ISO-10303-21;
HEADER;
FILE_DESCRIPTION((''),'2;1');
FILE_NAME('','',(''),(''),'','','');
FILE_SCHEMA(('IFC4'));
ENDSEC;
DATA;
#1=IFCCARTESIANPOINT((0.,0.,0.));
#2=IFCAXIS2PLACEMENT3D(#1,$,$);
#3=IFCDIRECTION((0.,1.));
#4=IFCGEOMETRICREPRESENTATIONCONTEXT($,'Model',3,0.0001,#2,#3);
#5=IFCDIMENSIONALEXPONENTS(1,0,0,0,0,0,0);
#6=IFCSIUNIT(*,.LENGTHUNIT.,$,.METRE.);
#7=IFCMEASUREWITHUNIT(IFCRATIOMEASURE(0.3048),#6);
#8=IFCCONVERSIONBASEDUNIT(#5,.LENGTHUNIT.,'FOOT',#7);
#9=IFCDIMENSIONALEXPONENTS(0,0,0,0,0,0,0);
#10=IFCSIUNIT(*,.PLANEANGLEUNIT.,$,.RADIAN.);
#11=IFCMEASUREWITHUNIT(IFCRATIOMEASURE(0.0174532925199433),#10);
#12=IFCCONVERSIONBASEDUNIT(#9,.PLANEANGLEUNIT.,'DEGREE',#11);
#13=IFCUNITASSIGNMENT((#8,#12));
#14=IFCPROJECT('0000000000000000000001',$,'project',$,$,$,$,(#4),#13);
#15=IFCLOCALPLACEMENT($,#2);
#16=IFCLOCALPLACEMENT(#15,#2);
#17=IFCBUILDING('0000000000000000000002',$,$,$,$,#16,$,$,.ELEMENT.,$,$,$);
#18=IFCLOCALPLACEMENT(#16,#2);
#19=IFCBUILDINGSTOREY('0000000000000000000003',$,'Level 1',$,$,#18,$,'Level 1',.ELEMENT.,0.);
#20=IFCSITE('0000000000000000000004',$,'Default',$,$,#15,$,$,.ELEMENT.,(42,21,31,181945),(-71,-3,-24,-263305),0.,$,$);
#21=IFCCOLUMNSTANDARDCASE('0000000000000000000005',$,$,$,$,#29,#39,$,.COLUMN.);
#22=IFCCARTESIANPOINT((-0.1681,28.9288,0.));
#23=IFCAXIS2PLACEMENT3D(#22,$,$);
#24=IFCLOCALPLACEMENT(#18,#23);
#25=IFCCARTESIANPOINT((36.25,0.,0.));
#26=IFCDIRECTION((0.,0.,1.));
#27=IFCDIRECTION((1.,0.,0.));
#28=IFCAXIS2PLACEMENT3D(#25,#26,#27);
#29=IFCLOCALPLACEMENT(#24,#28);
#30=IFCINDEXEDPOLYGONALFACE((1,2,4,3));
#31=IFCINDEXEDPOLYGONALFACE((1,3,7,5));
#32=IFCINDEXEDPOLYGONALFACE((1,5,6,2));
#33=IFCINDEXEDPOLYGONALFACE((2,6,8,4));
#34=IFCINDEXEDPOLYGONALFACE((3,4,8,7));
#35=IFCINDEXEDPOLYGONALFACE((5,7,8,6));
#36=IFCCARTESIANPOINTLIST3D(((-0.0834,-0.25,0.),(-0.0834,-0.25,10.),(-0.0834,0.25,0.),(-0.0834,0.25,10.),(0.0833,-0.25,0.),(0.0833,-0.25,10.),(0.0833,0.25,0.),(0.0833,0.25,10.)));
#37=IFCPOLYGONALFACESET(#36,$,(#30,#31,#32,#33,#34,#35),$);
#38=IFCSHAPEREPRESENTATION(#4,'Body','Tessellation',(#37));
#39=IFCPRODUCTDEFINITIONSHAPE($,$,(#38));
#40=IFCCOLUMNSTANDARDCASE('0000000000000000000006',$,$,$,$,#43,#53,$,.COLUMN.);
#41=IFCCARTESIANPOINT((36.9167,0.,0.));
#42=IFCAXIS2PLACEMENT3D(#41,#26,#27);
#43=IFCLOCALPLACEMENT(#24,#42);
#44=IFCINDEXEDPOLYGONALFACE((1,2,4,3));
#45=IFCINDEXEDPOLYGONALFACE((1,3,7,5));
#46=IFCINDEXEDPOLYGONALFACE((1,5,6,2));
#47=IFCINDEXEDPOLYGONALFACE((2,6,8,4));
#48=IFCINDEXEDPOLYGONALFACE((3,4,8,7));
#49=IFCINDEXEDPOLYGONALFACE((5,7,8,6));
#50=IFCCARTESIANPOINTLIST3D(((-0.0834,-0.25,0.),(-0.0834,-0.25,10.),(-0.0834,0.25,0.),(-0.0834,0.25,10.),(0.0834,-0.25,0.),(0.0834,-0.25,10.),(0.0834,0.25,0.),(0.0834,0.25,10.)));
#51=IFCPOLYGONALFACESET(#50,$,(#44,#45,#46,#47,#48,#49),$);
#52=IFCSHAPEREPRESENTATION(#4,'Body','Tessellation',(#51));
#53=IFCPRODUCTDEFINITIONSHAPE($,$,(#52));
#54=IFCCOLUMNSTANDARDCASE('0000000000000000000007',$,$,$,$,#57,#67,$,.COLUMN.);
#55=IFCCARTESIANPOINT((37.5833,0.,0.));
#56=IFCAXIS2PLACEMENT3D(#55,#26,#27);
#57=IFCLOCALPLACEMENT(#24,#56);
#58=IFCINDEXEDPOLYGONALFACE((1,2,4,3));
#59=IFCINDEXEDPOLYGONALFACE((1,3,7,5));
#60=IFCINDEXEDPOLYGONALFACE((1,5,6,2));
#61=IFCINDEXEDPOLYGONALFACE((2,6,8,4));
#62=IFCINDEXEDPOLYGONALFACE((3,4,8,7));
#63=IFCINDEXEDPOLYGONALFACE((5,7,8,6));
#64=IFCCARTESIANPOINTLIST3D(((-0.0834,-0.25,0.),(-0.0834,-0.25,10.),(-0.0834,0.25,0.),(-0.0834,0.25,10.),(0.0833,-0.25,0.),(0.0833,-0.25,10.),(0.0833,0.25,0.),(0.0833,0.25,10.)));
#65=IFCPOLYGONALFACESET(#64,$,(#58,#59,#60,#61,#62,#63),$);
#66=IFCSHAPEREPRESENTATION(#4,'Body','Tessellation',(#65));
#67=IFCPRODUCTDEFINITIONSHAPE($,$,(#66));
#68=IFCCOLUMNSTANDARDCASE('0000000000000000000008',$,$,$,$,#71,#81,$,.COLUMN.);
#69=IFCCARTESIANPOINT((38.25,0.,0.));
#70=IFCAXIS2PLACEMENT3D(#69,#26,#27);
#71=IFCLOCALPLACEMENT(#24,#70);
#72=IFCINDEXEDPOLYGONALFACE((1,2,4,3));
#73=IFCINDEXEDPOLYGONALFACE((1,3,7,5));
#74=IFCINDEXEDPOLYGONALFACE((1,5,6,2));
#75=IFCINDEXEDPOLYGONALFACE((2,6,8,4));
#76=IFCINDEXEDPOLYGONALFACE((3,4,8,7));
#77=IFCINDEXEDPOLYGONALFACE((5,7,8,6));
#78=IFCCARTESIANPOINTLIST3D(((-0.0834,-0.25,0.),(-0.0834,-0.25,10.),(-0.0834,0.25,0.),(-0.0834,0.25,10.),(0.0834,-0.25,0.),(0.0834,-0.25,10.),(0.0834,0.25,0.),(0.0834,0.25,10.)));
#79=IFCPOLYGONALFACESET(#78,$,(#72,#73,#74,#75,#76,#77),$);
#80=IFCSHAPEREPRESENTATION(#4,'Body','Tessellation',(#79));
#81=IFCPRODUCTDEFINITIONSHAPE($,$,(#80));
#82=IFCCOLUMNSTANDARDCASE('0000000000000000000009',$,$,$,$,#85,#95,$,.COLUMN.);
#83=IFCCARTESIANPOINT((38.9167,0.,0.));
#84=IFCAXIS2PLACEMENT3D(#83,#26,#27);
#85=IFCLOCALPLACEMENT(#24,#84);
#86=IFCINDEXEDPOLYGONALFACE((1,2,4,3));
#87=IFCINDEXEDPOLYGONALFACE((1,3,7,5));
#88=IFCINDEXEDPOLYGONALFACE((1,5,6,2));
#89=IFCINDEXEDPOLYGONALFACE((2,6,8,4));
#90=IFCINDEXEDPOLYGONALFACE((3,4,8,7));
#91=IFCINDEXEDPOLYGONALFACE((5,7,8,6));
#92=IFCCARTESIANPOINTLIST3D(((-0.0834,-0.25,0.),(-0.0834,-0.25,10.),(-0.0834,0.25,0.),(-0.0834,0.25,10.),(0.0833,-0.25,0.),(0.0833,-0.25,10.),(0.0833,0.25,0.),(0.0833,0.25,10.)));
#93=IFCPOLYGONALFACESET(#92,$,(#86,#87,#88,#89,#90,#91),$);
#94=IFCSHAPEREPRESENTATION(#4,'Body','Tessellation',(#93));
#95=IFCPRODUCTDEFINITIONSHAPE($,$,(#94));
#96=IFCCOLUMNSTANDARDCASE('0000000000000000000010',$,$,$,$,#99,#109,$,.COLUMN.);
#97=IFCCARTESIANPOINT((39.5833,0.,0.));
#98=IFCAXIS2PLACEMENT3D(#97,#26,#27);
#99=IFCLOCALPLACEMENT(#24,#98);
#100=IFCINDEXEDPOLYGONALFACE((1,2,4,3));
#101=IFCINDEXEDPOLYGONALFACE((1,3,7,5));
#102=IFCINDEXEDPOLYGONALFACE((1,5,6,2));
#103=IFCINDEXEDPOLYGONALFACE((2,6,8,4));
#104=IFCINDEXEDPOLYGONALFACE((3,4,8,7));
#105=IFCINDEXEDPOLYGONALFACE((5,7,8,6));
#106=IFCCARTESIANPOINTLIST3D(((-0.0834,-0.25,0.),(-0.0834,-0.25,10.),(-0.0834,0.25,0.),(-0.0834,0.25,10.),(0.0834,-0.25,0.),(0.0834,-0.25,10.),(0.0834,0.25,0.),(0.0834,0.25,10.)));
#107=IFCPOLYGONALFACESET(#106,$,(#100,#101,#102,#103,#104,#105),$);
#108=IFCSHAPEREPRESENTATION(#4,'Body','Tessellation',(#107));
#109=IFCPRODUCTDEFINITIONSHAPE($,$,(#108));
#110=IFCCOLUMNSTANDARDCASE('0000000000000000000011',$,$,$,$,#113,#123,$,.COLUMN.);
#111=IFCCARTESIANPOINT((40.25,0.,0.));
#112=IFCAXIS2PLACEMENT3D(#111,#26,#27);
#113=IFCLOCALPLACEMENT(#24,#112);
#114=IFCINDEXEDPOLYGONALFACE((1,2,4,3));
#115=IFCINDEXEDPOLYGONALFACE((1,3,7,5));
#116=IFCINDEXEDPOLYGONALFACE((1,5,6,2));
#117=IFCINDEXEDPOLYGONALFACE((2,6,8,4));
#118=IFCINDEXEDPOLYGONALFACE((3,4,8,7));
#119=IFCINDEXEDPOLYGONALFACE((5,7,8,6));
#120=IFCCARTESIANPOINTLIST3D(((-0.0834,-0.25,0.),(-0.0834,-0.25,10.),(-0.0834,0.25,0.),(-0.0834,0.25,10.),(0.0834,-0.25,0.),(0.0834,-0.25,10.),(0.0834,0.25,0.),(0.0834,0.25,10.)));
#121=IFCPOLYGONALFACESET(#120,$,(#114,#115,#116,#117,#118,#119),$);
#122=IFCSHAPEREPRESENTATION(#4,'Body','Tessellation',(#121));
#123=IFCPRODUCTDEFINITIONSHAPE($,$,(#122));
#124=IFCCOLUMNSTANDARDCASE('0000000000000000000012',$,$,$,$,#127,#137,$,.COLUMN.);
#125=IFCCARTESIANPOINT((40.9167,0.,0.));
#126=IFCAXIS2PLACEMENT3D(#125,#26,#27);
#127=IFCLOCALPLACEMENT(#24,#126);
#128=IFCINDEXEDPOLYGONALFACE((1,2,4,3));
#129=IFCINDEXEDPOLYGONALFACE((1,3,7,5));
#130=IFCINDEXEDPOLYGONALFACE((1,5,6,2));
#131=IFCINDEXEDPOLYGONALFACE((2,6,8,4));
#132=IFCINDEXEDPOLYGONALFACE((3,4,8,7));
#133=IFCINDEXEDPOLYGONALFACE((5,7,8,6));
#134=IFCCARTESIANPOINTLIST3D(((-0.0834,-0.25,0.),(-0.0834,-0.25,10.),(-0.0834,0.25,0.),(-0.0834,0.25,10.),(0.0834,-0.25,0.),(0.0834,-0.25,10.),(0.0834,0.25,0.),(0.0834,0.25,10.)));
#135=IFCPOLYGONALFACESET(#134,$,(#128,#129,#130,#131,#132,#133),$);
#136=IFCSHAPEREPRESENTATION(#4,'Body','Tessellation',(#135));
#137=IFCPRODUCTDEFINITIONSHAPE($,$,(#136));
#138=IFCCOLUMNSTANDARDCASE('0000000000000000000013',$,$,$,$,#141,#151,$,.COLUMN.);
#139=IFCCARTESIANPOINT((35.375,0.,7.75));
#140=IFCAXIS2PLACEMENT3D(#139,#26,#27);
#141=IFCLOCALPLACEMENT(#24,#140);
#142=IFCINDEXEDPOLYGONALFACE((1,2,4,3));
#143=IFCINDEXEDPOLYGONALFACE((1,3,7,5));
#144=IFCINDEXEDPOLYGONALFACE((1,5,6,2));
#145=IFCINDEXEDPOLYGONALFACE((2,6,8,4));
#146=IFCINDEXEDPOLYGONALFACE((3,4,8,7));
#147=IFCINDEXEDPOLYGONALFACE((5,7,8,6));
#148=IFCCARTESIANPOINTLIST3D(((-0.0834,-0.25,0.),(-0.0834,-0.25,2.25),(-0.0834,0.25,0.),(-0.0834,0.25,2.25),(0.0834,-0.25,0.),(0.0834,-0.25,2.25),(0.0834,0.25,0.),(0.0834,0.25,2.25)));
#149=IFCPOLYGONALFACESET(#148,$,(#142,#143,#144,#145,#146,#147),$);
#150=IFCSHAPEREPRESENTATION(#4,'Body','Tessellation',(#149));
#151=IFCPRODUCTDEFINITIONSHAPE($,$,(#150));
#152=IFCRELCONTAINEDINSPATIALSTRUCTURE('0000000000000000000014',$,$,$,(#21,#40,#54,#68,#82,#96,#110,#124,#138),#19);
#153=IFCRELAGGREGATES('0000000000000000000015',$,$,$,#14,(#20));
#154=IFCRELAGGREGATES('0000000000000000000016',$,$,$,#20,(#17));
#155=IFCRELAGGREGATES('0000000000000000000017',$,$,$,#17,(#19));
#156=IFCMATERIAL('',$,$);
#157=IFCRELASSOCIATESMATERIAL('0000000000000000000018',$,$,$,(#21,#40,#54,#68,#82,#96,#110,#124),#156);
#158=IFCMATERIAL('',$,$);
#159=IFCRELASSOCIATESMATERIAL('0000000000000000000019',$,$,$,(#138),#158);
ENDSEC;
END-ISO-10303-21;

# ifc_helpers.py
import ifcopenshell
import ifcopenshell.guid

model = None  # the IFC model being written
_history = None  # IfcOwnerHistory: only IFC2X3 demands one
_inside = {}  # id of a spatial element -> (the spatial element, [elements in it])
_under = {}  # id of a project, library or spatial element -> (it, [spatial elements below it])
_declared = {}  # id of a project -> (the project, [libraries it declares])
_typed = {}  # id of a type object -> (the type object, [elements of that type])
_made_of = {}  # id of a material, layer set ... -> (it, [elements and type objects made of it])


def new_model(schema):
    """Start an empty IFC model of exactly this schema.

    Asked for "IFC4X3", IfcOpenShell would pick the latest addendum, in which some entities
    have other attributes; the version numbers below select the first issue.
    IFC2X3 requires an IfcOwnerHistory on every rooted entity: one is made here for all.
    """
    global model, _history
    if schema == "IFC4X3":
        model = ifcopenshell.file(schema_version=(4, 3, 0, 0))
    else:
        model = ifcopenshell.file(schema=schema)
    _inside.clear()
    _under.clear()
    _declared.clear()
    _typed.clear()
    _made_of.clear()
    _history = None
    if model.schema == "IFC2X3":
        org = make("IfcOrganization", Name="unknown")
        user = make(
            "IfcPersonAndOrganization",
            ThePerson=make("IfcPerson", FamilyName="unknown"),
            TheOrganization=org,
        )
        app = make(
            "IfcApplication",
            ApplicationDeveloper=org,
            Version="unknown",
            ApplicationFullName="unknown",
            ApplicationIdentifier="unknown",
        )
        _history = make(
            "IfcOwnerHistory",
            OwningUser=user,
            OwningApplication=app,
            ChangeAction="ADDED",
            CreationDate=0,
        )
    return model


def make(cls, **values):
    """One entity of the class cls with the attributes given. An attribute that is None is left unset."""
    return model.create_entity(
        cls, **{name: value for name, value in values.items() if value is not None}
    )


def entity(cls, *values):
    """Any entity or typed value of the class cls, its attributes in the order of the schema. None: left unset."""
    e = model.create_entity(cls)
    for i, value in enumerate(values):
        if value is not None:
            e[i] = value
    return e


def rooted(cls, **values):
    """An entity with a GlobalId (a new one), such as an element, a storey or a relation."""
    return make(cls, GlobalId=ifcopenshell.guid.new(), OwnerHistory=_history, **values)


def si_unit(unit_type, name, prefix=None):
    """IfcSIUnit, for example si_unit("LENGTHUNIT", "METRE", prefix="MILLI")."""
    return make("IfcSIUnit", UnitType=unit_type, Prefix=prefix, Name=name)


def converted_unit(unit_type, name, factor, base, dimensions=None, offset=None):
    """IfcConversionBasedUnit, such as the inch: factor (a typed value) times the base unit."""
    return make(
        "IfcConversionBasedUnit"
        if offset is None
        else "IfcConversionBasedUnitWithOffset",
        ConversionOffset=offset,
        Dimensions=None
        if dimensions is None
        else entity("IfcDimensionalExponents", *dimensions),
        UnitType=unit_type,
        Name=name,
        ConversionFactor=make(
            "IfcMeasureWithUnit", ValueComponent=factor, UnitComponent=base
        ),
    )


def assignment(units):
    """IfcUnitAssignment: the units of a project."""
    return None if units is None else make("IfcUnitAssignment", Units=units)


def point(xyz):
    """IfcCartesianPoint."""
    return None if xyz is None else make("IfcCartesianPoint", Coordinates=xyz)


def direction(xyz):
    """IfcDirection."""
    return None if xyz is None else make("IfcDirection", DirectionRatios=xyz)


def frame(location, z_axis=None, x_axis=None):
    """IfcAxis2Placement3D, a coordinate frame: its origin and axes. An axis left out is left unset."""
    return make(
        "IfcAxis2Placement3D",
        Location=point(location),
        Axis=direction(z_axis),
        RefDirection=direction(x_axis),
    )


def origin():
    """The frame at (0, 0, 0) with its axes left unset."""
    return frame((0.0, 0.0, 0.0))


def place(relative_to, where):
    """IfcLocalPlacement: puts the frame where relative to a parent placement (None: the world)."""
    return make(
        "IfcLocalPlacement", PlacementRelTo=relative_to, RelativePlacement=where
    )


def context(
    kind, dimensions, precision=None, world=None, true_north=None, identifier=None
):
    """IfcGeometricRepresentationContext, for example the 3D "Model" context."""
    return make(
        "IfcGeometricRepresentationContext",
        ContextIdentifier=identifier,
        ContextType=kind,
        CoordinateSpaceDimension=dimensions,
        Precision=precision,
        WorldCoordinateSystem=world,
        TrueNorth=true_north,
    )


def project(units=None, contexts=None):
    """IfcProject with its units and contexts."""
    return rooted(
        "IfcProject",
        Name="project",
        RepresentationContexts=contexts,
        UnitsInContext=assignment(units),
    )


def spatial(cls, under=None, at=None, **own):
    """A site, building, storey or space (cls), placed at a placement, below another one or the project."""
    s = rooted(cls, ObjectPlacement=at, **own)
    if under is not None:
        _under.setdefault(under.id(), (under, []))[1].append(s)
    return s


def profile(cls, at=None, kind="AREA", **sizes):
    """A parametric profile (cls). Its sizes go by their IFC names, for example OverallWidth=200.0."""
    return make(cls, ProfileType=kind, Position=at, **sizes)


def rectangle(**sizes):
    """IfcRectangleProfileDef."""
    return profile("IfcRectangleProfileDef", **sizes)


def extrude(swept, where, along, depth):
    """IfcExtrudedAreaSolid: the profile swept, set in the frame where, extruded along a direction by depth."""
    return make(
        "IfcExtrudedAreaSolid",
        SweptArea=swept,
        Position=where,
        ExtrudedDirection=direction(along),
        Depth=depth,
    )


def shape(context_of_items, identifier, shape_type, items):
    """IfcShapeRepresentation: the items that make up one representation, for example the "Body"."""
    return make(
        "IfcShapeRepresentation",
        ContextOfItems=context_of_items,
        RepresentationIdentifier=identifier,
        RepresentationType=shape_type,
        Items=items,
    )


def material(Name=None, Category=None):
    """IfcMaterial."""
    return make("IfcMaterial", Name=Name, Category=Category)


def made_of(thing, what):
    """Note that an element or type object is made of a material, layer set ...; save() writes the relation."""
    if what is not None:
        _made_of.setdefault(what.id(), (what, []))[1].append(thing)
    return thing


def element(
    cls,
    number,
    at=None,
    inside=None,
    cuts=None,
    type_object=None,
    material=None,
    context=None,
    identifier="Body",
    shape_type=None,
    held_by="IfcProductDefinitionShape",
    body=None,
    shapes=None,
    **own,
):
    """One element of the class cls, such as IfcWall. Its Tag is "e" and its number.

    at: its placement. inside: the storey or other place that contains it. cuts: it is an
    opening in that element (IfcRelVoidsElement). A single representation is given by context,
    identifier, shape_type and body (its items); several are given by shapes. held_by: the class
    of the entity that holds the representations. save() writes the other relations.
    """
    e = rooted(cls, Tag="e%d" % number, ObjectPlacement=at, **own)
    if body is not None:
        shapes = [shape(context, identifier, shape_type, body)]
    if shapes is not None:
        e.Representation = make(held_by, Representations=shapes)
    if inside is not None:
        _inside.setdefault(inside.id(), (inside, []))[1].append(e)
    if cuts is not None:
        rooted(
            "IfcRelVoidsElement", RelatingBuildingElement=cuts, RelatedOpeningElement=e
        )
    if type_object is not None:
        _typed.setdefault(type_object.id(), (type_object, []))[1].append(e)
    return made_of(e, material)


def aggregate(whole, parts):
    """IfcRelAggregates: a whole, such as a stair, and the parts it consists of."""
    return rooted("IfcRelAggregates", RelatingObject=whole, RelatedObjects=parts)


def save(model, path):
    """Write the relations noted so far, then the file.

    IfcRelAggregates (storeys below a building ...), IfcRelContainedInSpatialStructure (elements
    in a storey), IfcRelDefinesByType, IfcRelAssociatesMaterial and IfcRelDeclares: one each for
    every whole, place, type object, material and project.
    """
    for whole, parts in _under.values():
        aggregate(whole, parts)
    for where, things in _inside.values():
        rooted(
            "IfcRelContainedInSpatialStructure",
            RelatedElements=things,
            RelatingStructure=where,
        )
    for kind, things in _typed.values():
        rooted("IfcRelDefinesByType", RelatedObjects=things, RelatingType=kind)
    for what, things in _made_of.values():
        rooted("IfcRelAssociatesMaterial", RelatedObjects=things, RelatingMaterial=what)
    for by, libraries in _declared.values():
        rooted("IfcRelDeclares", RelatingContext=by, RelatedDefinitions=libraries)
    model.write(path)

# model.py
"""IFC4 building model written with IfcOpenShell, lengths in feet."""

from ifc_helpers import new_model, entity, si_unit, converted_unit, direction, frame, origin, place, context, project, spatial, rectangle, extrude, material, element, save


model = new_model("IFC4")

# Units and contexts
model_context = context("Model", 3, precision=0.0001, world=origin(), true_north=direction((0.0, 1.0)))
ifc_project = project(units=[converted_unit("LENGTHUNIT", "FOOT", entity("IfcRatioMeasure", 0.3048), si_unit("LENGTHUNIT", "METRE"), dimensions=[1, 0, 0, 0, 0, 0, 0]), converted_unit("PLANEANGLEUNIT", "DEGREE", entity("IfcRatioMeasure", 0.0174532925199433), si_unit("PLANEANGLEUNIT", "RADIAN"), dimensions=[0, 0, 0, 0, 0, 0, 0])], contexts=[model_context])

# Site, building, storey
site_placement = place(None, origin())
site = spatial("IfcSite", under=ifc_project, at=site_placement, Name="Default", CompositionType="ELEMENT", RefLatitude=(42, 21, 31, 181945), RefLongitude=(-71, -3, -24, -263305), RefElevation=0.0)
building_placement = place(site_placement, origin())
building = spatial("IfcBuilding", under=site, at=building_placement, CompositionType="ELEMENT")
storey_placement = place(building_placement, origin())
storey = spatial("IfcBuildingStorey", under=building, at=storey_placement, Name="Level 1", LongName="Level 1", CompositionType="ELEMENT", Elevation=0.0)

# Columns
ifc_material_1 = material(Name="")
placement = place(storey_placement, frame((-0.1681, 28.9288, 0.0)))
for number, where, z_axis, x_axis in (
    (1, (36.25, 0.0, 0.0), (0.0, 0.0, 1.0), (1.0, 0.0, 0.0)),
    (2, (36.9167, 0.0, 0.0), (0.0, 0.0, 1.0), (1.0, 0.0, 0.0)),
    (3, (37.5833, 0.0, 0.0), (0.0, 0.0, 1.0), (1.0, 0.0, 0.0)),
    (4, (38.25, 0.0, 0.0), (0.0, 0.0, 1.0), (1.0, 0.0, 0.0)),
    (5, (38.9167, 0.0, 0.0), (0.0, 0.0, 1.0), (1.0, 0.0, 0.0)),
    (6, (39.5833, 0.0, 0.0), (0.0, 0.0, 1.0), (1.0, 0.0, 0.0)),
    (7, (40.25, 0.0, 0.0), (0.0, 0.0, 1.0), (1.0, 0.0, 0.0)),
    (8, (40.9167, 0.0, 0.0), (0.0, 0.0, 1.0), (1.0, 0.0, 0.0)),
):
    element("IfcColumnStandardCase", number, at=place(placement, frame(where, z_axis=z_axis, x_axis=x_axis)), inside=storey, material=ifc_material_1, PredefinedType="COLUMN", context=model_context, shape_type="SweptSolid", body=[
        extrude(rectangle(XDim=0.1667, YDim=0.5), origin(), (0.0, 0.0, 1.0), 10.0),
    ])
ifc_material_2 = material(Name="")
for number, where, z_axis, x_axis in (
    (9, (35.375, 0.0, 7.75), (0.0, 0.0, 1.0), (1.0, 0.0, 0.0)),
):
    element("IfcColumnStandardCase", number, at=place(placement, frame(where, z_axis=z_axis, x_axis=x_axis)), inside=storey, material=ifc_material_2, PredefinedType="COLUMN", context=model_context, shape_type="SweptSolid", body=[
        extrude(rectangle(XDim=0.1667, YDim=0.5), origin(), (0.0, 0.0, 1.0), 2.25),
    ])

save(model, "model.ifc")
